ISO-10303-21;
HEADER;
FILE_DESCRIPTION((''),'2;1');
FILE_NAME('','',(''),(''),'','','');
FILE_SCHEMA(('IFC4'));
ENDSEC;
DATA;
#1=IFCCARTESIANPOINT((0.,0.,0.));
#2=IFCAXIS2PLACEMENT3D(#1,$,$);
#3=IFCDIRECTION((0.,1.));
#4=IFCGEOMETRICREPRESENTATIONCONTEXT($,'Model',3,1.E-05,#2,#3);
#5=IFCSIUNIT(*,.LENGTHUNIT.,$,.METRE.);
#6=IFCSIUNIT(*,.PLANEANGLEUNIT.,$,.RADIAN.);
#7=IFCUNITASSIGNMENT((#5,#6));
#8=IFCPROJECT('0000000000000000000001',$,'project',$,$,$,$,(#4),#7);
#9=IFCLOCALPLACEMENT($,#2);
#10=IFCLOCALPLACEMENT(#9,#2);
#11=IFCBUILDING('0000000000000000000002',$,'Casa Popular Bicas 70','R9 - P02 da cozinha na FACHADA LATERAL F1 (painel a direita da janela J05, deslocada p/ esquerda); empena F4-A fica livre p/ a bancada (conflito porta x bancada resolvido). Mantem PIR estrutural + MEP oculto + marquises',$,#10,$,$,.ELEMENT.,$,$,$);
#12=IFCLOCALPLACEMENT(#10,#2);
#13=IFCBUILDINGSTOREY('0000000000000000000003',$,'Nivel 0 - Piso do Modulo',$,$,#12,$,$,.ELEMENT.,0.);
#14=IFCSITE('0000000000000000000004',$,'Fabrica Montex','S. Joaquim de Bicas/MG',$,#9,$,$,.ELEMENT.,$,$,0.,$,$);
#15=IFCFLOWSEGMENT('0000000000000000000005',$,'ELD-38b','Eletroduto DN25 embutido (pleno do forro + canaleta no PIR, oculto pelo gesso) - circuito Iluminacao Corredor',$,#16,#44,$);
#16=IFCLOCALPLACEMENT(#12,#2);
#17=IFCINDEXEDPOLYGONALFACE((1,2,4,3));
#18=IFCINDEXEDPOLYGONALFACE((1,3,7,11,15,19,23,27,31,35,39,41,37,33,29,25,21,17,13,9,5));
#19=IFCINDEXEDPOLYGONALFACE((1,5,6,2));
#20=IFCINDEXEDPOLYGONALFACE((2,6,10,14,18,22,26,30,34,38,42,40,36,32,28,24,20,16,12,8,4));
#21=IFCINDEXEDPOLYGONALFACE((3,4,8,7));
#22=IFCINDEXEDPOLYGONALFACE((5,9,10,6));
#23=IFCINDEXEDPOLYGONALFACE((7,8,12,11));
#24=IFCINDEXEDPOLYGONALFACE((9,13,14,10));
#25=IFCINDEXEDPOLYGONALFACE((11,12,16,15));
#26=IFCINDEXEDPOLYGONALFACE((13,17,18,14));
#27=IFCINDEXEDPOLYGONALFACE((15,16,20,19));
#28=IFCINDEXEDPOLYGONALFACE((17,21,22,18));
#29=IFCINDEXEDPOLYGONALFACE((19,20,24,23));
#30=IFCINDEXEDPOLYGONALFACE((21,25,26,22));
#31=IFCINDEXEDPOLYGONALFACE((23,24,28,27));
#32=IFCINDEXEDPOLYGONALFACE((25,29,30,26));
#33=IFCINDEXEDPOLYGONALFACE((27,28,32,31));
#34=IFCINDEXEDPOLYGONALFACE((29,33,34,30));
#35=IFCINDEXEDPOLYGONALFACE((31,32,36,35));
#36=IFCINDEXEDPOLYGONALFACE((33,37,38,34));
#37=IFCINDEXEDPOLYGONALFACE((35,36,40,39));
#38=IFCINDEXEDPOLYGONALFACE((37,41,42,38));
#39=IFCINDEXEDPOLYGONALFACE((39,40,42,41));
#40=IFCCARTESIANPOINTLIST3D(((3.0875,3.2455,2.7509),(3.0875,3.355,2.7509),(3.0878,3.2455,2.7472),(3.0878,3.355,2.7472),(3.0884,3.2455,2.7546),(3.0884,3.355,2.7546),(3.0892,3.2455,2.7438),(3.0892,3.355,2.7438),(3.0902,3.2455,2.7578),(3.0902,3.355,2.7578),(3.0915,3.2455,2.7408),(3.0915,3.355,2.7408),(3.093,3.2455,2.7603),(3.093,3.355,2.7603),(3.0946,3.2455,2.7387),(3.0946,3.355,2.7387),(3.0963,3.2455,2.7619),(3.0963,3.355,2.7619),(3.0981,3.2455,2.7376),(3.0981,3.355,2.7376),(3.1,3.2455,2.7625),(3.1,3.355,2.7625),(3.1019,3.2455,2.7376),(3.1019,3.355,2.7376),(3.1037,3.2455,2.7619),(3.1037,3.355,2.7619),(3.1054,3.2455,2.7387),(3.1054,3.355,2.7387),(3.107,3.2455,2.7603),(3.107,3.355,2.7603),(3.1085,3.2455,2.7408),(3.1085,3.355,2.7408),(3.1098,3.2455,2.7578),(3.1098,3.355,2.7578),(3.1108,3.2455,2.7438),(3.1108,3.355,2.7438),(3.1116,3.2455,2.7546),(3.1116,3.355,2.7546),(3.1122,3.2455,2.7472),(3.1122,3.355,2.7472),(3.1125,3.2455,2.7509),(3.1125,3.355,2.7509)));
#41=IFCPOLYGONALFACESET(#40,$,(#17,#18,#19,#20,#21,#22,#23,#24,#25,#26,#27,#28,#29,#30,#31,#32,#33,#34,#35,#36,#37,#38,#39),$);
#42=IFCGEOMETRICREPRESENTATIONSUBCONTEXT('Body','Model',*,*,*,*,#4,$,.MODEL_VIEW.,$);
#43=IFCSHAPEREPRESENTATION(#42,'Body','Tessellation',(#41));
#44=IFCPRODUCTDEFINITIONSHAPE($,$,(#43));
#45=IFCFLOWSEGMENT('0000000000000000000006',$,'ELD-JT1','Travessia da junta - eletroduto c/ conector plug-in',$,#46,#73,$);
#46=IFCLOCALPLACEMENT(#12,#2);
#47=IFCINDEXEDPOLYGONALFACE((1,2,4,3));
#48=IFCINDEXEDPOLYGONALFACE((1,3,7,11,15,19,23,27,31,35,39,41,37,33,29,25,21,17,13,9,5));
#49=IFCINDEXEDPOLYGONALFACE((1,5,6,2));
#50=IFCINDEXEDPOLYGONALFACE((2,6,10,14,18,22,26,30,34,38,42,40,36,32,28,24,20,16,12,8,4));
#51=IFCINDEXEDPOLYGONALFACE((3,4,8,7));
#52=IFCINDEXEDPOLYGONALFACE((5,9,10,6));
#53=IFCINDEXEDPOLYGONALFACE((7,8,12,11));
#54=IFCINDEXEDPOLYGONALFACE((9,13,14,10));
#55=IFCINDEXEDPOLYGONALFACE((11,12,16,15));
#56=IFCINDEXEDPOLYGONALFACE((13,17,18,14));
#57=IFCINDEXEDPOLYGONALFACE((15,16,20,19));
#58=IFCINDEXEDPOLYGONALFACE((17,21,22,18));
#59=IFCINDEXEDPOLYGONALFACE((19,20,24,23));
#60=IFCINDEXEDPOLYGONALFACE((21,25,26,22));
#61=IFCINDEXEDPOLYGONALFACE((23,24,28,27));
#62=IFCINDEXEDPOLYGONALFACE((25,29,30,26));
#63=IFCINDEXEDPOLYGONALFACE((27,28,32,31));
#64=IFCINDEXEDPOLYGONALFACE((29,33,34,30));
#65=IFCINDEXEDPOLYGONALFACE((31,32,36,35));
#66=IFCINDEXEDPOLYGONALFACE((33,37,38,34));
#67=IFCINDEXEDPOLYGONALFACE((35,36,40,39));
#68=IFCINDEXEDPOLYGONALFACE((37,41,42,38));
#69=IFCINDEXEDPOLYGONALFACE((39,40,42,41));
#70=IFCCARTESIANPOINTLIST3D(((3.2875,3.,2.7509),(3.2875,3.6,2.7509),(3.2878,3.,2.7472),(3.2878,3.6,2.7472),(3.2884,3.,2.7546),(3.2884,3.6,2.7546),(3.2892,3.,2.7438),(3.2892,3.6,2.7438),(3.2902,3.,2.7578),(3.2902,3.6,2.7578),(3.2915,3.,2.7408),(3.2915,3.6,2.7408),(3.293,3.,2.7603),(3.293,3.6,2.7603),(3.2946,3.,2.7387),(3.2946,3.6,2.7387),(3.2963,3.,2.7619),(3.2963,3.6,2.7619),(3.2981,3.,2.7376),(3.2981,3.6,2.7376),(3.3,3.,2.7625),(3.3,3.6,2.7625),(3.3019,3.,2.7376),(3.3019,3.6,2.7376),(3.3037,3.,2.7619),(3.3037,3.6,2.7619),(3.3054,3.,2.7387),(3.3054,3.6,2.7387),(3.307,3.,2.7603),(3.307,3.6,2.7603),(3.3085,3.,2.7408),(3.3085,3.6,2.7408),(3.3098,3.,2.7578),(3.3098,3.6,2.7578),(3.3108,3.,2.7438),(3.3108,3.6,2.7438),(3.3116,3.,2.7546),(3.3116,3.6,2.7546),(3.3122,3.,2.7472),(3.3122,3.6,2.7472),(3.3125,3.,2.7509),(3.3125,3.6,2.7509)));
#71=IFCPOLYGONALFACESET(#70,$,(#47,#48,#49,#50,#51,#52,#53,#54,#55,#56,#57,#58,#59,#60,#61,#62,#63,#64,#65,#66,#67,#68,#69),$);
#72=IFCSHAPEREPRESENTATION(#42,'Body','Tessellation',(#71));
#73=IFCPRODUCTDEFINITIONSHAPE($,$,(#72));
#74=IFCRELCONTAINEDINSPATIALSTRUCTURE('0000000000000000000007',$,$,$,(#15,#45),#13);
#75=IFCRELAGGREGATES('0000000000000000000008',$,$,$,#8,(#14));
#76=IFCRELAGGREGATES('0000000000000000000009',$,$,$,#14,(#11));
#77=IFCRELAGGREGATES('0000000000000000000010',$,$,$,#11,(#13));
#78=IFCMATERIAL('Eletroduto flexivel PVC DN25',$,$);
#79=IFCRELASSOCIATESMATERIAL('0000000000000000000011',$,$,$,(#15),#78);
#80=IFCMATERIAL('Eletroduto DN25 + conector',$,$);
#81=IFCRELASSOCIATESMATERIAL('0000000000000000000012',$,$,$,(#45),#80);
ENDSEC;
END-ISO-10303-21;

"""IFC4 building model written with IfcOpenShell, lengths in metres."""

from ifc_helpers import new_model, si_unit, direction, frame, origin, origin_2d, place, context, subcontext, project, spatial, circle, extrude, material, element, save


model = new_model("IFC4")

# Units and contexts
model_context = context("Model", 3, precision=1e-05, world=origin(), true_north=direction((0.0, 1.0)))
body_context = subcontext(model_context, "Body", "Model", "MODEL_VIEW")
ifc_project = project(units=[si_unit("LENGTHUNIT", "METRE"), si_unit("PLANEANGLEUNIT", "RADIAN")], contexts=[model_context])

# Site, building, storey
site_placement = place(None, origin())
site = spatial("IfcSite", under=ifc_project, at=site_placement, Name="Fabrica Montex", Description="S. Joaquim de Bicas/MG", CompositionType="ELEMENT", RefElevation=0.0)
building_placement = place(site_placement, origin())
building = spatial("IfcBuilding", under=site, at=building_placement, Name="Casa Popular Bicas 70", Description="R9 - P02 da cozinha na FACHADA LATERAL F1 (painel a direita da janela J05, deslocada p/ esquerda); empena F4-A fica livre p/ a bancada (conflito porta x bancada resolvido). Mantem PIR estrutural + MEP oculto + marquises", CompositionType="ELEMENT")
storey_placement = place(building_placement, origin())
storey = spatial("IfcBuildingStorey", under=building, at=storey_placement, Name="Nivel 0 - Piso do Modulo", CompositionType="ELEMENT", Elevation=0.0)

# Shared definitions
ifc_material_1 = material(Name="Eletroduto flexivel PVC DN25")

# Flow segments
flow_segment_1_placement = place(storey_placement, frame((3.1, 3.2455, 2.75), z_axis=(0.0, 1.0, 0.0), x_axis=(0.0, 0.0, 1.0)))
element("IfcFlowSegment", 1, at=flow_segment_1_placement, inside=storey, material=ifc_material_1, Name="ELD-38b", Description="Eletroduto DN25 embutido (pleno do forro + canaleta no PIR, oculto pelo gesso) - circuito Iluminacao Corredor", context=body_context, shape_type="SweptSolid", body=[
    extrude(circle(Radius=0.0125, at=origin_2d()), origin(), (0.0, 0.0, 1.0), 0.1095),
])
ifc_material_2 = material(Name="Eletroduto DN25 + conector")
flow_segment_2_placement = place(storey_placement, frame((3.3, 3.0, 2.75), z_axis=(0.0, 1.0, 0.0), x_axis=(0.0, 0.0, 1.0)))
element("IfcFlowSegment", 2, at=flow_segment_2_placement, inside=storey, material=ifc_material_2, Name="ELD-JT1", Description="Travessia da junta - eletroduto c/ conector plug-in", context=body_context, shape_type="SweptSolid", body=[
    extrude(circle(Radius=0.0125, at=origin_2d()), origin(), (0.0, 0.0, 1.0), 0.6),
])

save(model, "model.ifc")
